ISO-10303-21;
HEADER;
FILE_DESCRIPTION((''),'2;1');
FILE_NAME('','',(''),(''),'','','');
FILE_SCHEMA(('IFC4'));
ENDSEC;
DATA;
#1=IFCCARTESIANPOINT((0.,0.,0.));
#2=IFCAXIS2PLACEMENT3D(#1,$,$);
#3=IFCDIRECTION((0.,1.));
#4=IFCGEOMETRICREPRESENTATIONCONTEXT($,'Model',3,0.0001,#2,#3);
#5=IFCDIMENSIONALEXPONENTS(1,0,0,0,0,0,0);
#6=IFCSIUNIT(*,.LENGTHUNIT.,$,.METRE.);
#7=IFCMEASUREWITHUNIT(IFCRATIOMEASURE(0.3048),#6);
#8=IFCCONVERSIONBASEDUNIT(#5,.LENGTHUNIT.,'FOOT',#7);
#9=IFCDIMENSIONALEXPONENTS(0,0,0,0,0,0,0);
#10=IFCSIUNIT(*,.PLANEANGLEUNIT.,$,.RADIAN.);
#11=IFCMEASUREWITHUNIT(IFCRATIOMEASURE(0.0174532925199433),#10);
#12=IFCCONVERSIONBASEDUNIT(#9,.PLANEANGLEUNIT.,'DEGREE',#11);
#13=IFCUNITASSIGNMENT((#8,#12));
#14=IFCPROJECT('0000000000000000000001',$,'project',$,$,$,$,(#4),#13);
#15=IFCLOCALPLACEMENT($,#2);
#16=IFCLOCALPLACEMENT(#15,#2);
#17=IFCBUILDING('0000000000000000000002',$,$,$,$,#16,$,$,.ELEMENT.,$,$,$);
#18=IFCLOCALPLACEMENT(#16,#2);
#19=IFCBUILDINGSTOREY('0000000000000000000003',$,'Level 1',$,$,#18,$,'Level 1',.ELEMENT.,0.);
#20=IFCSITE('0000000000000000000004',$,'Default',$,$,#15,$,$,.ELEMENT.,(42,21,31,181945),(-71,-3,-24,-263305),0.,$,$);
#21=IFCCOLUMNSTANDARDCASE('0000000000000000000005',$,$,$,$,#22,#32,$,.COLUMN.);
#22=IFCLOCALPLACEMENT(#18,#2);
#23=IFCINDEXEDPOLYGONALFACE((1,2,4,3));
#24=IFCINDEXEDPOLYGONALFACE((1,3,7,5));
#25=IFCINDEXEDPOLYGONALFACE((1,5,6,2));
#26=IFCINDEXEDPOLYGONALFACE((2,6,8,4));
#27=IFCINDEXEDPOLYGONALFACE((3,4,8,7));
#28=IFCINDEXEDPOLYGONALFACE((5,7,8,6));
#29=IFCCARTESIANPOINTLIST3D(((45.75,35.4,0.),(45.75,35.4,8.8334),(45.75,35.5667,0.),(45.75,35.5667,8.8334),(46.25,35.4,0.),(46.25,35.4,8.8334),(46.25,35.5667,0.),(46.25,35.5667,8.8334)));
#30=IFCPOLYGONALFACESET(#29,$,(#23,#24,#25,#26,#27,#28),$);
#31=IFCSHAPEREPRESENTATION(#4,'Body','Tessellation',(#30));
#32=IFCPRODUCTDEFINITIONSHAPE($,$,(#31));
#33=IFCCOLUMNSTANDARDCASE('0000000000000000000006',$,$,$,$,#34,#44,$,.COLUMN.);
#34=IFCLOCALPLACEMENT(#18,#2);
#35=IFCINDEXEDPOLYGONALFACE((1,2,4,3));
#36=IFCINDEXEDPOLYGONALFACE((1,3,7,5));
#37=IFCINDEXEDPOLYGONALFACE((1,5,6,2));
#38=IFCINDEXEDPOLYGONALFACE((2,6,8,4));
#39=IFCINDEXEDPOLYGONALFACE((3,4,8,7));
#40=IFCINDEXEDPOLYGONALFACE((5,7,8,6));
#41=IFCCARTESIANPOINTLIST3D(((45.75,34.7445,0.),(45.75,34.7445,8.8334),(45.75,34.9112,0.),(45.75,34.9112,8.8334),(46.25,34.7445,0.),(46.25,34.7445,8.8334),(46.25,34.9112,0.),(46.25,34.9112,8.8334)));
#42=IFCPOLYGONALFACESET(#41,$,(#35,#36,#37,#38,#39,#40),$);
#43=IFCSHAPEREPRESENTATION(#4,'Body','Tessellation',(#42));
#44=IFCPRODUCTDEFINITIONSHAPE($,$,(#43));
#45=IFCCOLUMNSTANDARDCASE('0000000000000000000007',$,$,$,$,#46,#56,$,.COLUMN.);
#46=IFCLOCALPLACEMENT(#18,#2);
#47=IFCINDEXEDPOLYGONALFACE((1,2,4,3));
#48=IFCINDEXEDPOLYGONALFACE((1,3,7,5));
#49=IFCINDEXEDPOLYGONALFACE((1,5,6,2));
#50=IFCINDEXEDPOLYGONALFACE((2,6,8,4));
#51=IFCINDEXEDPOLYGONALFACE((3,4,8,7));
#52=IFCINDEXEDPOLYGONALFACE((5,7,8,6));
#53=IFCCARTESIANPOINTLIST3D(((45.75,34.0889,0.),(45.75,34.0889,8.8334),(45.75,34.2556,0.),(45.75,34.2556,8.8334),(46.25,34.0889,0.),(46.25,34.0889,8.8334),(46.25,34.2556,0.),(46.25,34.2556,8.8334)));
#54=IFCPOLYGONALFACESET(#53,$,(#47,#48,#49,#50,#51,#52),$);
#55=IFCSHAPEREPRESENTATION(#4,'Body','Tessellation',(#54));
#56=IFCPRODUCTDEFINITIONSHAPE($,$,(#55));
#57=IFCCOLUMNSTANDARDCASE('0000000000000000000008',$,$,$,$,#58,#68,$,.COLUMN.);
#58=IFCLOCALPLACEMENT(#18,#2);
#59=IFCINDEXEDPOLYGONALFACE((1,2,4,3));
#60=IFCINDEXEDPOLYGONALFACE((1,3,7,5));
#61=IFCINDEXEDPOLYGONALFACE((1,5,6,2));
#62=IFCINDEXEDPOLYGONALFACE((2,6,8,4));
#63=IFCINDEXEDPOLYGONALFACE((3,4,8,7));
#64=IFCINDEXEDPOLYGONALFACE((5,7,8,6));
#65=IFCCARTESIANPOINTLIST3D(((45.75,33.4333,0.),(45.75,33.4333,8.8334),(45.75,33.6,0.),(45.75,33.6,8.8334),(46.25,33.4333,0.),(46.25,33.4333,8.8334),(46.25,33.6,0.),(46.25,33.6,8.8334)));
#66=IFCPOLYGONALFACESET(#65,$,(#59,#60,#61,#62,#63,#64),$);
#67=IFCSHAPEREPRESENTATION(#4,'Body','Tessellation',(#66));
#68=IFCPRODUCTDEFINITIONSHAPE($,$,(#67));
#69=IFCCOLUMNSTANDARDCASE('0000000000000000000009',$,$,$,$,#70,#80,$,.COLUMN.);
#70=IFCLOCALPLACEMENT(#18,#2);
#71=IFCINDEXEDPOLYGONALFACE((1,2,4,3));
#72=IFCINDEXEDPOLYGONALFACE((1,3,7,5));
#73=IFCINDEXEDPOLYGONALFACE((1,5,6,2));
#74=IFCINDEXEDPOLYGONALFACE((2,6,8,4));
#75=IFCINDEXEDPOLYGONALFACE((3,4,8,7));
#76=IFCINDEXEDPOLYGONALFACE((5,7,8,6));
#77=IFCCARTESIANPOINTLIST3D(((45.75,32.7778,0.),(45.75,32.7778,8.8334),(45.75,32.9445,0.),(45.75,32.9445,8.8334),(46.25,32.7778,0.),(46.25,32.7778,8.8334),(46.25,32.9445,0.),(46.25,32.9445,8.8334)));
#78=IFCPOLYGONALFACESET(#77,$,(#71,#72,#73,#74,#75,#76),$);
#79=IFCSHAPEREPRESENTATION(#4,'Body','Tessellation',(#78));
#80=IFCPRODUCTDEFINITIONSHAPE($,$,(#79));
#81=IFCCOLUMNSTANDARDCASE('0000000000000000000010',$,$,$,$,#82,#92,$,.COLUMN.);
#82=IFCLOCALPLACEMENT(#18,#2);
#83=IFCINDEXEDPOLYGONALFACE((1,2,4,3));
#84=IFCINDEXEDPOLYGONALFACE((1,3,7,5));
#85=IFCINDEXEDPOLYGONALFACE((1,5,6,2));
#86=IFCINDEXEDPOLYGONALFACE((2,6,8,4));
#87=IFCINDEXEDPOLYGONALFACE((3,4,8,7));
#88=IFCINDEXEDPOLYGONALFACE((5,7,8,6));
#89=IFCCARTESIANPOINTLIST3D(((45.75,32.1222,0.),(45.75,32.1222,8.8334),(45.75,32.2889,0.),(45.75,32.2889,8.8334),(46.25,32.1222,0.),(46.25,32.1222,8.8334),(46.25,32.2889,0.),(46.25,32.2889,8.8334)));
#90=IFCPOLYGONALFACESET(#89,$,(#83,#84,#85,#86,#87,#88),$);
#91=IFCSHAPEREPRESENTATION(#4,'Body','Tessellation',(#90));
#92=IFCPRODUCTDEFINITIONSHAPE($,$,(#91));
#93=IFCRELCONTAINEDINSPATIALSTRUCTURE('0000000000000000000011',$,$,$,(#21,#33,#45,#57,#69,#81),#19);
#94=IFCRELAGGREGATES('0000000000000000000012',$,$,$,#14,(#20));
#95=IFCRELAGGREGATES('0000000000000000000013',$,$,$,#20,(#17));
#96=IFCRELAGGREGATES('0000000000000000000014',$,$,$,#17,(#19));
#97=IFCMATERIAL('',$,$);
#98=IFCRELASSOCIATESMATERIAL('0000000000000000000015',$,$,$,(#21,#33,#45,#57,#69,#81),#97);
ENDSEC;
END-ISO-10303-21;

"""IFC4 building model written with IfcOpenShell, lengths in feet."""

from ifc_helpers import new_model, entity, si_unit, converted_unit, direction, frame, origin, place, context, project, spatial, rectangle, extrude, material, element, save


model = new_model("IFC4")

# Units and contexts
model_context = context("Model", 3, precision=0.0001, world=origin(), true_north=direction((0.0, 1.0)))
ifc_project = project(units=[converted_unit("LENGTHUNIT", "FOOT", entity("IfcRatioMeasure", 0.3048), si_unit("LENGTHUNIT", "METRE"), dimensions=[1, 0, 0, 0, 0, 0, 0]), converted_unit("PLANEANGLEUNIT", "DEGREE", entity("IfcRatioMeasure", 0.0174532925199433), si_unit("PLANEANGLEUNIT", "RADIAN"), dimensions=[0, 0, 0, 0, 0, 0, 0])], contexts=[model_context])

# Site, building, storey
site_placement = place(None, origin())
site = spatial("IfcSite", under=ifc_project, at=site_placement, Name="Default", CompositionType="ELEMENT", RefLatitude=(42, 21, 31, 181945), RefLongitude=(-71, -3, -24, -263305), RefElevation=0.0)
building_placement = place(site_placement, origin())
building = spatial("IfcBuilding", under=site, at=building_placement, CompositionType="ELEMENT")
storey_placement = place(building_placement, origin())
storey = spatial("IfcBuildingStorey", under=building, at=storey_placement, Name="Level 1", LongName="Level 1", CompositionType="ELEMENT", Elevation=0.0)

# Columns
ifc_material_1 = material(Name="")
placement_1 = place(storey_placement, frame((46.0, 46.25, 0.0), z_axis=(0.0, 0.0, 1.0), x_axis=(0.0, -1.0, 0.0)))
for number, where, z_axis, x_axis in (
    (1, (10.7667, 0.0, 0.0), (0.0, 0.0, 1.0), (1.0, 0.0, 0.0)),
    (2, (11.4222, 0.0, 0.0), (0.0, 0.0, 1.0), (1.0, 0.0, 0.0)),
    (3, (12.0778, 0.0, 0.0), (0.0, 0.0, 1.0), (1.0, 0.0, 0.0)),
    (4, (12.7334, 0.0, 0.0), (0.0, 0.0, 1.0), (1.0, 0.0, 0.0)),
    (5, (13.3889, 0.0, 0.0), (0.0, 0.0, 1.0), (1.0, 0.0, 0.0)),
    (6, (14.0445, 0.0, 0.0), (0.0, 0.0, 1.0), (1.0, 0.0, 0.0)),
):
    element("IfcColumnStandardCase", number, at=place(placement_1, frame(where, z_axis=z_axis, x_axis=x_axis)), inside=storey, material=ifc_material_1, PredefinedType="COLUMN", context=model_context, shape_type="SweptSolid", body=[
        extrude(rectangle(XDim=0.1667, YDim=0.5), origin(), (0.0, 0.0, 1.0), 8.8334),
    ])

save(model, "model.ifc")
